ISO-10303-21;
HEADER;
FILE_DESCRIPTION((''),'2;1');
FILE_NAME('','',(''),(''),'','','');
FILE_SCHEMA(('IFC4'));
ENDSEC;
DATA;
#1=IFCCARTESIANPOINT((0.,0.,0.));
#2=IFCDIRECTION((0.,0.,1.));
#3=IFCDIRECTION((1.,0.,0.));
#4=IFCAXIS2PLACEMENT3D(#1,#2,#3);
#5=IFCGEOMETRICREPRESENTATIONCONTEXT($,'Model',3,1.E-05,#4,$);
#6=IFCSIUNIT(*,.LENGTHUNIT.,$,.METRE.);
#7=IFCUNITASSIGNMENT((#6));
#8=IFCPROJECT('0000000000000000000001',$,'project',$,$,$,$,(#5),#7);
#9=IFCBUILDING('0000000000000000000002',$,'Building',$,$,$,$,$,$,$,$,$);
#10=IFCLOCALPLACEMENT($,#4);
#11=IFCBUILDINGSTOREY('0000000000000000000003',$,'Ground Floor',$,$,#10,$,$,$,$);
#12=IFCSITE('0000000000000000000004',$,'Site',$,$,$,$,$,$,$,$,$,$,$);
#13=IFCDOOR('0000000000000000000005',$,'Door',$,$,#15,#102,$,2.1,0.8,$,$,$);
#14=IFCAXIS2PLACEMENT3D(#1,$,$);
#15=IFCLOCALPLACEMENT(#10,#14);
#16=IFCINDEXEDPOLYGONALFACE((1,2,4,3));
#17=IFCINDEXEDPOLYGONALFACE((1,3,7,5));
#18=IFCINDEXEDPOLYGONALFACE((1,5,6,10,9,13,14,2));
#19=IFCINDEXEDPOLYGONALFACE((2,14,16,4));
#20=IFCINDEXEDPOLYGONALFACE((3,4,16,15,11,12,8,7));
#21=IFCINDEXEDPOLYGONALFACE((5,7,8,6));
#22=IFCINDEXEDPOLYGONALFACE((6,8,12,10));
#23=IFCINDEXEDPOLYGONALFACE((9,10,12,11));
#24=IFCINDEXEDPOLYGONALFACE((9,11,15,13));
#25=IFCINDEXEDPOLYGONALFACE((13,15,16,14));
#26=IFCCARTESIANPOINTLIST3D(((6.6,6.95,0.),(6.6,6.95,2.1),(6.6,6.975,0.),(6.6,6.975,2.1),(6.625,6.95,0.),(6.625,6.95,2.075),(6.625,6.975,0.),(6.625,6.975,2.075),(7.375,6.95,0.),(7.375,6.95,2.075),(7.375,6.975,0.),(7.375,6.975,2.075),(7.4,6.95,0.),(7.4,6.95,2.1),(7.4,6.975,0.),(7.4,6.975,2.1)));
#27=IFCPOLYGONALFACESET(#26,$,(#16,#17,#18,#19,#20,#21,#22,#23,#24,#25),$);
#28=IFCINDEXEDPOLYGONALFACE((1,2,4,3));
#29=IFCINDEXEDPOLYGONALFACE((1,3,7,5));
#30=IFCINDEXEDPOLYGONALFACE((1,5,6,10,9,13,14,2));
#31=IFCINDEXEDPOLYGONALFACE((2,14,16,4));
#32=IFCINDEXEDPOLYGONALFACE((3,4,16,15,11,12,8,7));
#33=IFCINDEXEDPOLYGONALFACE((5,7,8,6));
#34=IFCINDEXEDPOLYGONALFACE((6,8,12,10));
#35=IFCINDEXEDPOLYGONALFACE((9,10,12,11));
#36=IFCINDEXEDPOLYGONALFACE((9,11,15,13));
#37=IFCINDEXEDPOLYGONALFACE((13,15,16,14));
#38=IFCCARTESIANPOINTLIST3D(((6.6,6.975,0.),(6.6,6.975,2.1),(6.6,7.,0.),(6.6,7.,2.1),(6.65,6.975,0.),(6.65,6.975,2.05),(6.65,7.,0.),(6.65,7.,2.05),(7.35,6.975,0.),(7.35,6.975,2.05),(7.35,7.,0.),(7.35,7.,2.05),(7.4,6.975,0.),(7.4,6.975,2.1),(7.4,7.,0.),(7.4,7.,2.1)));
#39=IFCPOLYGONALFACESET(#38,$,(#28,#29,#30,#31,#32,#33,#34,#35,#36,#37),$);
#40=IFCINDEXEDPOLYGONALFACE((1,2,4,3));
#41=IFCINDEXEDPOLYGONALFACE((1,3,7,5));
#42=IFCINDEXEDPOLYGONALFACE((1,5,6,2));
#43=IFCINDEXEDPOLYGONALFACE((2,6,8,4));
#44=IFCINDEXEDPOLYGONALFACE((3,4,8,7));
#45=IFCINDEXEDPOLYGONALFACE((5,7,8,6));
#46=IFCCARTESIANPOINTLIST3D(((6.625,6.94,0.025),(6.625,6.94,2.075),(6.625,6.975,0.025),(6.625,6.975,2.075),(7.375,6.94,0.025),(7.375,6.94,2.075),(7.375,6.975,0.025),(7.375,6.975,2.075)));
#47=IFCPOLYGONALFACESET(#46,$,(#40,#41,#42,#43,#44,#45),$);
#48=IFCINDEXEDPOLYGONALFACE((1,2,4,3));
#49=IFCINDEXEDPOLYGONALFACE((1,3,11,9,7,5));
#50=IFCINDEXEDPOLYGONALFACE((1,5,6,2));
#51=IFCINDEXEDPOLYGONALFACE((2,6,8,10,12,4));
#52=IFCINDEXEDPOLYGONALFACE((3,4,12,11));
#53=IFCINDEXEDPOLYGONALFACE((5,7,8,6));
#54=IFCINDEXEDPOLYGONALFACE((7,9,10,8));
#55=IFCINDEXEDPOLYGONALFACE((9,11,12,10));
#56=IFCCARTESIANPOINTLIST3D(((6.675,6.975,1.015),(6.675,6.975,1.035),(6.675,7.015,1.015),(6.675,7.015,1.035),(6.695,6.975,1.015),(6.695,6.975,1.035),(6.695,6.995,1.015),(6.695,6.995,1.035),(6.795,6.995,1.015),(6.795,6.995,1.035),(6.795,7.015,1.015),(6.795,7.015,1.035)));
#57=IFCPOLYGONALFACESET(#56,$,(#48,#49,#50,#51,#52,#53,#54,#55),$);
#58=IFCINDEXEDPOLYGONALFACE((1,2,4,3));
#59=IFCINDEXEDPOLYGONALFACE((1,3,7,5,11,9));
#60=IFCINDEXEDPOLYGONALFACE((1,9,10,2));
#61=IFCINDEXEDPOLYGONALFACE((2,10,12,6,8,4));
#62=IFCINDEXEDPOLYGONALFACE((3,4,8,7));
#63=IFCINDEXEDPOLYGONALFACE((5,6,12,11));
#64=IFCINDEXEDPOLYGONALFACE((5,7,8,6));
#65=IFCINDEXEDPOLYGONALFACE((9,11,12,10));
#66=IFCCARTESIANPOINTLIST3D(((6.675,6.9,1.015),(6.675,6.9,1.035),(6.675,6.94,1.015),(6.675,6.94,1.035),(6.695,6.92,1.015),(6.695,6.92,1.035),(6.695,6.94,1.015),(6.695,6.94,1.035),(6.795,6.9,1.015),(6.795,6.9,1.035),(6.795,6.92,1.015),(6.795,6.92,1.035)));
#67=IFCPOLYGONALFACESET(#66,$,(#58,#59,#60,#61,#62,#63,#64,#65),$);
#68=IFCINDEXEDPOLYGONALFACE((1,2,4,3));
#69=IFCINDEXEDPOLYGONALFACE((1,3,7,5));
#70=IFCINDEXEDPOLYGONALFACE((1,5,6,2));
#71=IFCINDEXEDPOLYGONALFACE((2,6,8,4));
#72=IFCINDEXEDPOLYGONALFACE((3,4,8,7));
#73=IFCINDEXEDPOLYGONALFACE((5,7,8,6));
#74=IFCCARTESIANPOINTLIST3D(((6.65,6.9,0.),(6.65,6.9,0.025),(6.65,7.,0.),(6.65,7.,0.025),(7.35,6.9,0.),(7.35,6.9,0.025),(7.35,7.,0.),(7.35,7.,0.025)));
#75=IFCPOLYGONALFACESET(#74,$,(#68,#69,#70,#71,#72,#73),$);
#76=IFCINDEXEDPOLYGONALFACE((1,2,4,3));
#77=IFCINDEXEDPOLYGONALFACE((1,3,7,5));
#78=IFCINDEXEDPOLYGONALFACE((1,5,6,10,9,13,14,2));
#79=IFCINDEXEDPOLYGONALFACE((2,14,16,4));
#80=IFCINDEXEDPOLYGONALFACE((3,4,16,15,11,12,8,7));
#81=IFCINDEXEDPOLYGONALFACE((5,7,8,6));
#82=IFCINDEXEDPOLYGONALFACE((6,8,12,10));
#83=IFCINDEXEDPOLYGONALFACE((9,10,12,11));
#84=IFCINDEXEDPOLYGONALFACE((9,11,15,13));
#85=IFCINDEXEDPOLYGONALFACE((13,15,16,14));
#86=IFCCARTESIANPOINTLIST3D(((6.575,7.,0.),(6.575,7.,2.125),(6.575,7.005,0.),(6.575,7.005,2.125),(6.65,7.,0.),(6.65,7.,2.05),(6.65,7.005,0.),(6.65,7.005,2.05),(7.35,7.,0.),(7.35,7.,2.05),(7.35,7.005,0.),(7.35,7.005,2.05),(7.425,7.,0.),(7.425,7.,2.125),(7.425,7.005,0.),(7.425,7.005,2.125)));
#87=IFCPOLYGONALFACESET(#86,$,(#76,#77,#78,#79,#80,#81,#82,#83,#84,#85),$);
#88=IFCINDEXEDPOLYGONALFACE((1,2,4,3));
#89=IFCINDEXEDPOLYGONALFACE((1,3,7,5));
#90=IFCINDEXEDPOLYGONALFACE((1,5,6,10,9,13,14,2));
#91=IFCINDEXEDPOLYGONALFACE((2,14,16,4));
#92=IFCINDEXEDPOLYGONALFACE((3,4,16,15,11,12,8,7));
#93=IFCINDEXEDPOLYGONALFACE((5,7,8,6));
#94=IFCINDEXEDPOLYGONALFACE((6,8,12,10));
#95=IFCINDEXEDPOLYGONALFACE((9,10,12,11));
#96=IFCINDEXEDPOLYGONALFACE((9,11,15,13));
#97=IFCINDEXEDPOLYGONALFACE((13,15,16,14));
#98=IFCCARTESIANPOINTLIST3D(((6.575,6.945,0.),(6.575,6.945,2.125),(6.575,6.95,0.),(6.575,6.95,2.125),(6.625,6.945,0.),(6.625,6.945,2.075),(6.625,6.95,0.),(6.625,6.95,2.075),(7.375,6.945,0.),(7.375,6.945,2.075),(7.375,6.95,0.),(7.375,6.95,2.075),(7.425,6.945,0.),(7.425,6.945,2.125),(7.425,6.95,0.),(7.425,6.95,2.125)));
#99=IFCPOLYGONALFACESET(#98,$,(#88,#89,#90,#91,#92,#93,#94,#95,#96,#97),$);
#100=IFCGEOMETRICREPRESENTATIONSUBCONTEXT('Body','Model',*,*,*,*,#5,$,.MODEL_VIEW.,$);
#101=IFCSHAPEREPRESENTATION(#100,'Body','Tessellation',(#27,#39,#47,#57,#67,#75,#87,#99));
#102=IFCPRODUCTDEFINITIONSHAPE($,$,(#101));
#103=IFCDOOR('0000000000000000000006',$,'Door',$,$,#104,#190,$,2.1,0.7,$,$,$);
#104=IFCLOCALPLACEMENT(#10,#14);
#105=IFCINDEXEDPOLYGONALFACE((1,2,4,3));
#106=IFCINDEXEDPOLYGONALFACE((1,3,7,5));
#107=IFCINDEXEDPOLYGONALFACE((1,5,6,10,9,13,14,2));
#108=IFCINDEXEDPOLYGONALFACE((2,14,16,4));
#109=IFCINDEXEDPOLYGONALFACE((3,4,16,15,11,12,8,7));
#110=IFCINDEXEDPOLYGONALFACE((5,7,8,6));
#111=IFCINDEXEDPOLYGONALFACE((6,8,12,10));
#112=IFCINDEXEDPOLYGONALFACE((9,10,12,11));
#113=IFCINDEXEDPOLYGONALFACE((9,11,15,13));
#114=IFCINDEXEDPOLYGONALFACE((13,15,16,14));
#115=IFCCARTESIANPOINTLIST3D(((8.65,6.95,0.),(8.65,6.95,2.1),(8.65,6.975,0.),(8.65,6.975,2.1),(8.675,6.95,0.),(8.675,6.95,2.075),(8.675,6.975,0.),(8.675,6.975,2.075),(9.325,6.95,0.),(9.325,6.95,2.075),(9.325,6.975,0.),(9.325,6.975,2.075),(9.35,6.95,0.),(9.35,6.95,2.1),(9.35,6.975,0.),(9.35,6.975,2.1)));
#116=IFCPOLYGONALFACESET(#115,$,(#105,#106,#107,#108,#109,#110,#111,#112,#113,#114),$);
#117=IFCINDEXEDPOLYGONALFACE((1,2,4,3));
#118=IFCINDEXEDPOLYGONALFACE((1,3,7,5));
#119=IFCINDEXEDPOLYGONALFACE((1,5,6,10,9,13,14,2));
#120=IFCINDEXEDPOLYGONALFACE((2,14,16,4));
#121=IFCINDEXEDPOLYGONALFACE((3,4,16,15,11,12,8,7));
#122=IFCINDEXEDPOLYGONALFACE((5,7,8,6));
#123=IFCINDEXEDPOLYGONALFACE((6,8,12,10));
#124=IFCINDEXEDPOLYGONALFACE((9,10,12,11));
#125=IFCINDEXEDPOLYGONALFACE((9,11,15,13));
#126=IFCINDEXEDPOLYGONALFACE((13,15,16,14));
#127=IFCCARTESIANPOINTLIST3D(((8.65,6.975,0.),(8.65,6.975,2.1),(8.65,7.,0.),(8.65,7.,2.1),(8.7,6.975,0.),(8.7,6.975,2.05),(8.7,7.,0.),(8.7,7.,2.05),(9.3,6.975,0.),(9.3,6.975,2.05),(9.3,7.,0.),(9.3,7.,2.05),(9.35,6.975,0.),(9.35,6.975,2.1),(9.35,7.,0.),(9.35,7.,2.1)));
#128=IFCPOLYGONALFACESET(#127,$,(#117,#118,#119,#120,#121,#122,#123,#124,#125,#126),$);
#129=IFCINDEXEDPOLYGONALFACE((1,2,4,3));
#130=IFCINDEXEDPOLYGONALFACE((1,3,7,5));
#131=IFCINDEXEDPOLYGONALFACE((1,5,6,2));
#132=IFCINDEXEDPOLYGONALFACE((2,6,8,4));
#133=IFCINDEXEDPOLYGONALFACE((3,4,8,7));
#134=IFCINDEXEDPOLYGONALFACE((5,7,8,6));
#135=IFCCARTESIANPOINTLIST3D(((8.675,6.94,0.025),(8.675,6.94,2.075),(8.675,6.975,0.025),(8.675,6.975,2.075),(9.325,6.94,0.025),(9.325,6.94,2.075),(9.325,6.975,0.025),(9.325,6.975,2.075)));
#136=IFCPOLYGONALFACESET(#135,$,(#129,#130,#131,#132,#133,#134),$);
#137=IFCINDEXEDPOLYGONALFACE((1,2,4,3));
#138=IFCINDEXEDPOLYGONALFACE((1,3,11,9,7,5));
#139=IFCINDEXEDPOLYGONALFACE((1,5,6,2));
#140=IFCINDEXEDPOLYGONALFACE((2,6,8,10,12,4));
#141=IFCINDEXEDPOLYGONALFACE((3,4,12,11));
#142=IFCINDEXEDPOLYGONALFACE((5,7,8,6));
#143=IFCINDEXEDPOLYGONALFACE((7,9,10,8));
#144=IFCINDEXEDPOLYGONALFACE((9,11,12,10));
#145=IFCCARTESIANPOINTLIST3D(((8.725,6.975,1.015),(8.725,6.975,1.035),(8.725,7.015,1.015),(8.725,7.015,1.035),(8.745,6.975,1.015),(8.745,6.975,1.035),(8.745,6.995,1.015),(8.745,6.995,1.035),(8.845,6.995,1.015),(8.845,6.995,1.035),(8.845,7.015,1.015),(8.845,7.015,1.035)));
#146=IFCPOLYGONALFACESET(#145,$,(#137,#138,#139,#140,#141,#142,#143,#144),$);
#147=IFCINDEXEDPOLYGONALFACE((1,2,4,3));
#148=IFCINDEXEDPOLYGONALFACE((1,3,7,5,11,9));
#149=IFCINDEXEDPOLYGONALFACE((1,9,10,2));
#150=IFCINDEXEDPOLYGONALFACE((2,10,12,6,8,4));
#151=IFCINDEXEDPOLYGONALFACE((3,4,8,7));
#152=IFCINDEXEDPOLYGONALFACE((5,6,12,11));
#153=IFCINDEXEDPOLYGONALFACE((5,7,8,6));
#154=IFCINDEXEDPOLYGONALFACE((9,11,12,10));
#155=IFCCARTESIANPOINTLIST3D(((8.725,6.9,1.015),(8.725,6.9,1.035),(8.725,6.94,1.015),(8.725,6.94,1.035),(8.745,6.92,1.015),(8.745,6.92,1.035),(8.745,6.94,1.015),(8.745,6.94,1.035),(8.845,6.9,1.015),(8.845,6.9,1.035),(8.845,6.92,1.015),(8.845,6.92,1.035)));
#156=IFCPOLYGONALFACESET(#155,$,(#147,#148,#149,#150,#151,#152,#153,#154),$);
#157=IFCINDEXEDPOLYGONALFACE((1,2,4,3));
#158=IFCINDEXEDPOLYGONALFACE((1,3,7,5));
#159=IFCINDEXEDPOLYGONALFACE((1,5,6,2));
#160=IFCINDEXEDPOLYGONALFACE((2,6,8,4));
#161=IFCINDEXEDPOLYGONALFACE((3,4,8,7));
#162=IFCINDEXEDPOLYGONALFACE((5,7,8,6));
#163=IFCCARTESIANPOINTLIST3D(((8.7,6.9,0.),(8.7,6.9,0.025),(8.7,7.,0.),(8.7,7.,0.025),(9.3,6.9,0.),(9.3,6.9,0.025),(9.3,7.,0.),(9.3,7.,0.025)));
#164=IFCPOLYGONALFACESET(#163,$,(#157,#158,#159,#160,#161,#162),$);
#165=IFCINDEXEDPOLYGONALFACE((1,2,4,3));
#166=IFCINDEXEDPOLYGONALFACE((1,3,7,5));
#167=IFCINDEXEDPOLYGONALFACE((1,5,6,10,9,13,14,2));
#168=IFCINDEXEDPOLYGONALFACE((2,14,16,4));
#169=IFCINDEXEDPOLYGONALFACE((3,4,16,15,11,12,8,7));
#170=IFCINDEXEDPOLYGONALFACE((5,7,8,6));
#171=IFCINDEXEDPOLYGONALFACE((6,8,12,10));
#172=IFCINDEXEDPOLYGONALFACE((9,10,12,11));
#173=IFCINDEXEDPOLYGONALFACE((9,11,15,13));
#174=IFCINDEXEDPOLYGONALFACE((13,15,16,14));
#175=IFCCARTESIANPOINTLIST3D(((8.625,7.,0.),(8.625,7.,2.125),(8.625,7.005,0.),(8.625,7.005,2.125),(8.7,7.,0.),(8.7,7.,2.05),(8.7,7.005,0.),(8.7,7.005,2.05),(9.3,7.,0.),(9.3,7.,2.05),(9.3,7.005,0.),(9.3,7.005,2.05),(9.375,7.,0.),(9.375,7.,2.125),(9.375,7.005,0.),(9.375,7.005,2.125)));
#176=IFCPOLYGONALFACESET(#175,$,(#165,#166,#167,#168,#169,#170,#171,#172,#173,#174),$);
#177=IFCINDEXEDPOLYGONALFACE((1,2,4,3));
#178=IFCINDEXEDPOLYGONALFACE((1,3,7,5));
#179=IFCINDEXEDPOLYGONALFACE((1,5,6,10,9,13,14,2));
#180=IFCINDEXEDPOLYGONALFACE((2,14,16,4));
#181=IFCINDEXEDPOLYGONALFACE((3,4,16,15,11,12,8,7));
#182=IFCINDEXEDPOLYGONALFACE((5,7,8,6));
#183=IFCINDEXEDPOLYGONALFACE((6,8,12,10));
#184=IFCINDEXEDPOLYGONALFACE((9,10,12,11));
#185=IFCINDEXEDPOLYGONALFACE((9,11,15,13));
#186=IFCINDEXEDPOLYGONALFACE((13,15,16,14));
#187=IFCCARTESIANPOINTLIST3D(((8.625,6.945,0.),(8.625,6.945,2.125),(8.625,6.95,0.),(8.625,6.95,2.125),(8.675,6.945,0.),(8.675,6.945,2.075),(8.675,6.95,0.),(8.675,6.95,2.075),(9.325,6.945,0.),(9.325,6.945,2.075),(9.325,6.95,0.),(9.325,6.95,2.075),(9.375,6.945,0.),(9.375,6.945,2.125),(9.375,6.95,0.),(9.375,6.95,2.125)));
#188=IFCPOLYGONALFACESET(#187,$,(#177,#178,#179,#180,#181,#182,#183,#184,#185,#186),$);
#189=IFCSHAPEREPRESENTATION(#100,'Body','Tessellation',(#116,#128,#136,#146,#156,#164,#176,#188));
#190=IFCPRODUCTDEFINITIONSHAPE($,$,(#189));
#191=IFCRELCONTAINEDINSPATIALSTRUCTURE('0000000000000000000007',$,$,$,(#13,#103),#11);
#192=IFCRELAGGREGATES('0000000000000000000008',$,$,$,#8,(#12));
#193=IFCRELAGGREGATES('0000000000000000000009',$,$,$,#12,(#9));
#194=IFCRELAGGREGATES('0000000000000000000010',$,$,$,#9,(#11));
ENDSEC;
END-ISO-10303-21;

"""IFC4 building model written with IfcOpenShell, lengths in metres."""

from ifc_helpers import new_model, si_unit, frame, origin_with_axes, place, context, subcontext, project, spatial, line, indexed_curve, outline, extrude, element, save


model = new_model("IFC4")

# Units and contexts
model_context = context("Model", 3, precision=1e-05, world=origin_with_axes())
body_context = subcontext(model_context, "Body", "Model", "MODEL_VIEW")
ifc_project = project(units=[si_unit("LENGTHUNIT", "METRE")], contexts=[model_context])

# Site, building, storey
site = spatial("IfcSite", under=ifc_project, Name="Site")
building = spatial("IfcBuilding", under=site, Name="Building")
storey_placement = place(None, origin_with_axes())
storey = spatial("IfcBuildingStorey", under=building, at=storey_placement, Name="Ground Floor")

# Doors
door_1_placement = place(storey_placement, frame((7.4, 7.0, 0.0), z_axis=(0.0, 0.0, 1.0), x_axis=(-1.0, 0.0, 0.0)))
element("IfcDoor", 1, at=door_1_placement, inside=storey, Name="Door", OverallHeight=2.1, OverallWidth=0.8, context=body_context, shape_type="SweptSolid", body=[
    extrude(outline(indexed_curve([(0.0, 0.0), (0.0, 2.1), (0.8, 2.1), (0.8, 0.0), (0.775, 0.0), (0.775, 2.075), (0.025, 2.075), (0.025, 0.0)], segments=[line(1, 2, 3, 4, 5, 6, 7, 8, 1)])), frame((0.0, 0.025, 0.0), z_axis=(0.0, -1.0, 0.0), x_axis=(1.0, 0.0, 0.0)), (0.0, 0.0, -1.0), 0.025),
    extrude(outline(indexed_curve([(0.0, 0.0), (0.0, 2.1), (0.8, 2.1), (0.8, 0.0), (0.75, 0.0), (0.75, 2.05), (0.05, 2.05), (0.05, 0.0)], segments=[line(1, 2, 3, 4, 5, 6, 7, 8, 1)])), frame((0.0, 0.0, 0.0), z_axis=(0.0, -1.0, 0.0), x_axis=(1.0, 0.0, 0.0)), (0.0, 0.0, -1.0), 0.025),
    extrude(outline(indexed_curve([(0.0, 0.0), (0.75, 0.0), (0.75, 0.035), (0.0, 0.035)], segments=[line(1, 2, 3, 4, 1)])), frame((0.025, 0.025, 0.025), z_axis=(0.0, 0.0, 1.0), x_axis=(1.0, 0.0, 0.0)), (0.0, 0.0, 1.0), 2.05),
    extrude(outline(indexed_curve([(0.0, 0.0), (0.0, -0.04), (-0.12, -0.04), (-0.12, -0.02), (-0.02, -0.02), (-0.02, 0.0)], segments=[line(1, 2, 3, 4, 5, 6, 1)])), frame((0.725, 0.025, 1.015), z_axis=(0.0, 0.0, 1.0), x_axis=(1.0, 0.0, 0.0)), (0.0, 0.0, 1.0), 0.02),
    extrude(outline(indexed_curve([(0.0, 0.0), (0.0, 0.04), (-0.12, 0.04), (-0.12, 0.02), (-0.02, 0.02), (-0.02, 0.0)], segments=[line(1, 2, 3, 4, 5, 6, 1)])), frame((0.725, 0.06, 1.015), z_axis=(0.0, 0.0, 1.0), x_axis=(1.0, 0.0, 0.0)), (0.0, 0.0, 1.0), 0.02),
    extrude(outline(indexed_curve([(0.0, 0.0), (0.7, 0.0), (0.7, 0.1), (0.0, 0.1)], segments=[line(1, 2, 3, 4, 1)])), frame((0.05, 0.0, 0.0), z_axis=(0.0, 0.0, 1.0), x_axis=(1.0, 0.0, 0.0)), (0.0, 0.0, 1.0), 0.025),
    extrude(outline(indexed_curve([(0.0, 0.0), (0.0, 2.125), (0.85, 2.125), (0.85, 0.0), (0.775, 0.0), (0.775, 2.05), (0.075, 2.05), (0.075, 0.0)], segments=[line(1, 2, 3, 4, 5, 6, 7, 8, 1)])), frame((-0.025, -0.005, 0.0), z_axis=(0.0, -1.0, 0.0), x_axis=(1.0, 0.0, 0.0)), (0.0, 0.0, -1.0), 0.005),
    extrude(outline(indexed_curve([(0.0, 0.0), (0.0, 2.125), (0.85, 2.125), (0.85, 0.0), (0.8, 0.0), (0.8, 2.075), (0.05, 2.075), (0.05, 0.0)], segments=[line(1, 2, 3, 4, 5, 6, 7, 8, 1)])), frame((-0.025, 0.05, 0.0), z_axis=(0.0, -1.0, 0.0), x_axis=(1.0, 0.0, 0.0)), (0.0, 0.0, -1.0), 0.005),
])
door_2_placement = place(storey_placement, frame((9.35, 7.0, 0.0), z_axis=(0.0, 0.0, 1.0), x_axis=(-1.0, 0.0, 0.0)))
element("IfcDoor", 2, at=door_2_placement, inside=storey, Name="Door", OverallHeight=2.1, OverallWidth=0.7, context=body_context, shape_type="SweptSolid", body=[
    extrude(outline(indexed_curve([(0.0, 0.0), (0.0, 2.1), (0.7, 2.1), (0.7, 0.0), (0.675, 0.0), (0.675, 2.075), (0.025, 2.075), (0.025, 0.0)], segments=[line(1, 2, 3, 4, 5, 6, 7, 8, 1)])), frame((0.0, 0.025, 0.0), z_axis=(0.0, -1.0, 0.0), x_axis=(1.0, 0.0, 0.0)), (0.0, 0.0, -1.0), 0.025),
    extrude(outline(indexed_curve([(0.0, 0.0), (0.0, 2.1), (0.7, 2.1), (0.7, 0.0), (0.65, 0.0), (0.65, 2.05), (0.05, 2.05), (0.05, 0.0)], segments=[line(1, 2, 3, 4, 5, 6, 7, 8, 1)])), frame((0.0, 0.0, 0.0), z_axis=(0.0, -1.0, 0.0), x_axis=(1.0, 0.0, 0.0)), (0.0, 0.0, -1.0), 0.025),
    extrude(outline(indexed_curve([(0.0, 0.0), (0.65, 0.0), (0.65, 0.035), (0.0, 0.035)], segments=[line(1, 2, 3, 4, 1)])), frame((0.025, 0.025, 0.025), z_axis=(0.0, 0.0, 1.0), x_axis=(1.0, 0.0, 0.0)), (0.0, 0.0, 1.0), 2.05),
    extrude(outline(indexed_curve([(0.0, 0.0), (0.0, -0.04), (-0.12, -0.04), (-0.12, -0.02), (-0.02, -0.02), (-0.02, 0.0)], segments=[line(1, 2, 3, 4, 5, 6, 1)])), frame((0.625, 0.025, 1.015), z_axis=(0.0, 0.0, 1.0), x_axis=(1.0, 0.0, 0.0)), (0.0, 0.0, 1.0), 0.02),
    extrude(outline(indexed_curve([(0.0, 0.0), (0.0, 0.04), (-0.12, 0.04), (-0.12, 0.02), (-0.02, 0.02), (-0.02, 0.0)], segments=[line(1, 2, 3, 4, 5, 6, 1)])), frame((0.625, 0.06, 1.015), z_axis=(0.0, 0.0, 1.0), x_axis=(1.0, 0.0, 0.0)), (0.0, 0.0, 1.0), 0.02),
    extrude(outline(indexed_curve([(0.0, 0.0), (0.6, 0.0), (0.6, 0.1), (0.0, 0.1)], segments=[line(1, 2, 3, 4, 1)])), frame((0.05, 0.0, 0.0), z_axis=(0.0, 0.0, 1.0), x_axis=(1.0, 0.0, 0.0)), (0.0, 0.0, 1.0), 0.025),
    extrude(outline(indexed_curve([(0.0, 0.0), (0.0, 2.125), (0.75, 2.125), (0.75, 0.0), (0.675, 0.0), (0.675, 2.05), (0.075, 2.05), (0.075, 0.0)], segments=[line(1, 2, 3, 4, 5, 6, 7, 8, 1)])), frame((-0.025, -0.005, 0.0), z_axis=(0.0, -1.0, 0.0), x_axis=(1.0, 0.0, 0.0)), (0.0, 0.0, -1.0), 0.005),
    extrude(outline(indexed_curve([(0.0, 0.0), (0.0, 2.125), (0.75, 2.125), (0.75, 0.0), (0.7, 0.0), (0.7, 2.075), (0.05, 2.075), (0.05, 0.0)], segments=[line(1, 2, 3, 4, 5, 6, 7, 8, 1)])), frame((-0.025, 0.05, 0.0), z_axis=(0.0, -1.0, 0.0), x_axis=(1.0, 0.0, 0.0)), (0.0, 0.0, -1.0), 0.005),
])

save(model, "model.ifc")
